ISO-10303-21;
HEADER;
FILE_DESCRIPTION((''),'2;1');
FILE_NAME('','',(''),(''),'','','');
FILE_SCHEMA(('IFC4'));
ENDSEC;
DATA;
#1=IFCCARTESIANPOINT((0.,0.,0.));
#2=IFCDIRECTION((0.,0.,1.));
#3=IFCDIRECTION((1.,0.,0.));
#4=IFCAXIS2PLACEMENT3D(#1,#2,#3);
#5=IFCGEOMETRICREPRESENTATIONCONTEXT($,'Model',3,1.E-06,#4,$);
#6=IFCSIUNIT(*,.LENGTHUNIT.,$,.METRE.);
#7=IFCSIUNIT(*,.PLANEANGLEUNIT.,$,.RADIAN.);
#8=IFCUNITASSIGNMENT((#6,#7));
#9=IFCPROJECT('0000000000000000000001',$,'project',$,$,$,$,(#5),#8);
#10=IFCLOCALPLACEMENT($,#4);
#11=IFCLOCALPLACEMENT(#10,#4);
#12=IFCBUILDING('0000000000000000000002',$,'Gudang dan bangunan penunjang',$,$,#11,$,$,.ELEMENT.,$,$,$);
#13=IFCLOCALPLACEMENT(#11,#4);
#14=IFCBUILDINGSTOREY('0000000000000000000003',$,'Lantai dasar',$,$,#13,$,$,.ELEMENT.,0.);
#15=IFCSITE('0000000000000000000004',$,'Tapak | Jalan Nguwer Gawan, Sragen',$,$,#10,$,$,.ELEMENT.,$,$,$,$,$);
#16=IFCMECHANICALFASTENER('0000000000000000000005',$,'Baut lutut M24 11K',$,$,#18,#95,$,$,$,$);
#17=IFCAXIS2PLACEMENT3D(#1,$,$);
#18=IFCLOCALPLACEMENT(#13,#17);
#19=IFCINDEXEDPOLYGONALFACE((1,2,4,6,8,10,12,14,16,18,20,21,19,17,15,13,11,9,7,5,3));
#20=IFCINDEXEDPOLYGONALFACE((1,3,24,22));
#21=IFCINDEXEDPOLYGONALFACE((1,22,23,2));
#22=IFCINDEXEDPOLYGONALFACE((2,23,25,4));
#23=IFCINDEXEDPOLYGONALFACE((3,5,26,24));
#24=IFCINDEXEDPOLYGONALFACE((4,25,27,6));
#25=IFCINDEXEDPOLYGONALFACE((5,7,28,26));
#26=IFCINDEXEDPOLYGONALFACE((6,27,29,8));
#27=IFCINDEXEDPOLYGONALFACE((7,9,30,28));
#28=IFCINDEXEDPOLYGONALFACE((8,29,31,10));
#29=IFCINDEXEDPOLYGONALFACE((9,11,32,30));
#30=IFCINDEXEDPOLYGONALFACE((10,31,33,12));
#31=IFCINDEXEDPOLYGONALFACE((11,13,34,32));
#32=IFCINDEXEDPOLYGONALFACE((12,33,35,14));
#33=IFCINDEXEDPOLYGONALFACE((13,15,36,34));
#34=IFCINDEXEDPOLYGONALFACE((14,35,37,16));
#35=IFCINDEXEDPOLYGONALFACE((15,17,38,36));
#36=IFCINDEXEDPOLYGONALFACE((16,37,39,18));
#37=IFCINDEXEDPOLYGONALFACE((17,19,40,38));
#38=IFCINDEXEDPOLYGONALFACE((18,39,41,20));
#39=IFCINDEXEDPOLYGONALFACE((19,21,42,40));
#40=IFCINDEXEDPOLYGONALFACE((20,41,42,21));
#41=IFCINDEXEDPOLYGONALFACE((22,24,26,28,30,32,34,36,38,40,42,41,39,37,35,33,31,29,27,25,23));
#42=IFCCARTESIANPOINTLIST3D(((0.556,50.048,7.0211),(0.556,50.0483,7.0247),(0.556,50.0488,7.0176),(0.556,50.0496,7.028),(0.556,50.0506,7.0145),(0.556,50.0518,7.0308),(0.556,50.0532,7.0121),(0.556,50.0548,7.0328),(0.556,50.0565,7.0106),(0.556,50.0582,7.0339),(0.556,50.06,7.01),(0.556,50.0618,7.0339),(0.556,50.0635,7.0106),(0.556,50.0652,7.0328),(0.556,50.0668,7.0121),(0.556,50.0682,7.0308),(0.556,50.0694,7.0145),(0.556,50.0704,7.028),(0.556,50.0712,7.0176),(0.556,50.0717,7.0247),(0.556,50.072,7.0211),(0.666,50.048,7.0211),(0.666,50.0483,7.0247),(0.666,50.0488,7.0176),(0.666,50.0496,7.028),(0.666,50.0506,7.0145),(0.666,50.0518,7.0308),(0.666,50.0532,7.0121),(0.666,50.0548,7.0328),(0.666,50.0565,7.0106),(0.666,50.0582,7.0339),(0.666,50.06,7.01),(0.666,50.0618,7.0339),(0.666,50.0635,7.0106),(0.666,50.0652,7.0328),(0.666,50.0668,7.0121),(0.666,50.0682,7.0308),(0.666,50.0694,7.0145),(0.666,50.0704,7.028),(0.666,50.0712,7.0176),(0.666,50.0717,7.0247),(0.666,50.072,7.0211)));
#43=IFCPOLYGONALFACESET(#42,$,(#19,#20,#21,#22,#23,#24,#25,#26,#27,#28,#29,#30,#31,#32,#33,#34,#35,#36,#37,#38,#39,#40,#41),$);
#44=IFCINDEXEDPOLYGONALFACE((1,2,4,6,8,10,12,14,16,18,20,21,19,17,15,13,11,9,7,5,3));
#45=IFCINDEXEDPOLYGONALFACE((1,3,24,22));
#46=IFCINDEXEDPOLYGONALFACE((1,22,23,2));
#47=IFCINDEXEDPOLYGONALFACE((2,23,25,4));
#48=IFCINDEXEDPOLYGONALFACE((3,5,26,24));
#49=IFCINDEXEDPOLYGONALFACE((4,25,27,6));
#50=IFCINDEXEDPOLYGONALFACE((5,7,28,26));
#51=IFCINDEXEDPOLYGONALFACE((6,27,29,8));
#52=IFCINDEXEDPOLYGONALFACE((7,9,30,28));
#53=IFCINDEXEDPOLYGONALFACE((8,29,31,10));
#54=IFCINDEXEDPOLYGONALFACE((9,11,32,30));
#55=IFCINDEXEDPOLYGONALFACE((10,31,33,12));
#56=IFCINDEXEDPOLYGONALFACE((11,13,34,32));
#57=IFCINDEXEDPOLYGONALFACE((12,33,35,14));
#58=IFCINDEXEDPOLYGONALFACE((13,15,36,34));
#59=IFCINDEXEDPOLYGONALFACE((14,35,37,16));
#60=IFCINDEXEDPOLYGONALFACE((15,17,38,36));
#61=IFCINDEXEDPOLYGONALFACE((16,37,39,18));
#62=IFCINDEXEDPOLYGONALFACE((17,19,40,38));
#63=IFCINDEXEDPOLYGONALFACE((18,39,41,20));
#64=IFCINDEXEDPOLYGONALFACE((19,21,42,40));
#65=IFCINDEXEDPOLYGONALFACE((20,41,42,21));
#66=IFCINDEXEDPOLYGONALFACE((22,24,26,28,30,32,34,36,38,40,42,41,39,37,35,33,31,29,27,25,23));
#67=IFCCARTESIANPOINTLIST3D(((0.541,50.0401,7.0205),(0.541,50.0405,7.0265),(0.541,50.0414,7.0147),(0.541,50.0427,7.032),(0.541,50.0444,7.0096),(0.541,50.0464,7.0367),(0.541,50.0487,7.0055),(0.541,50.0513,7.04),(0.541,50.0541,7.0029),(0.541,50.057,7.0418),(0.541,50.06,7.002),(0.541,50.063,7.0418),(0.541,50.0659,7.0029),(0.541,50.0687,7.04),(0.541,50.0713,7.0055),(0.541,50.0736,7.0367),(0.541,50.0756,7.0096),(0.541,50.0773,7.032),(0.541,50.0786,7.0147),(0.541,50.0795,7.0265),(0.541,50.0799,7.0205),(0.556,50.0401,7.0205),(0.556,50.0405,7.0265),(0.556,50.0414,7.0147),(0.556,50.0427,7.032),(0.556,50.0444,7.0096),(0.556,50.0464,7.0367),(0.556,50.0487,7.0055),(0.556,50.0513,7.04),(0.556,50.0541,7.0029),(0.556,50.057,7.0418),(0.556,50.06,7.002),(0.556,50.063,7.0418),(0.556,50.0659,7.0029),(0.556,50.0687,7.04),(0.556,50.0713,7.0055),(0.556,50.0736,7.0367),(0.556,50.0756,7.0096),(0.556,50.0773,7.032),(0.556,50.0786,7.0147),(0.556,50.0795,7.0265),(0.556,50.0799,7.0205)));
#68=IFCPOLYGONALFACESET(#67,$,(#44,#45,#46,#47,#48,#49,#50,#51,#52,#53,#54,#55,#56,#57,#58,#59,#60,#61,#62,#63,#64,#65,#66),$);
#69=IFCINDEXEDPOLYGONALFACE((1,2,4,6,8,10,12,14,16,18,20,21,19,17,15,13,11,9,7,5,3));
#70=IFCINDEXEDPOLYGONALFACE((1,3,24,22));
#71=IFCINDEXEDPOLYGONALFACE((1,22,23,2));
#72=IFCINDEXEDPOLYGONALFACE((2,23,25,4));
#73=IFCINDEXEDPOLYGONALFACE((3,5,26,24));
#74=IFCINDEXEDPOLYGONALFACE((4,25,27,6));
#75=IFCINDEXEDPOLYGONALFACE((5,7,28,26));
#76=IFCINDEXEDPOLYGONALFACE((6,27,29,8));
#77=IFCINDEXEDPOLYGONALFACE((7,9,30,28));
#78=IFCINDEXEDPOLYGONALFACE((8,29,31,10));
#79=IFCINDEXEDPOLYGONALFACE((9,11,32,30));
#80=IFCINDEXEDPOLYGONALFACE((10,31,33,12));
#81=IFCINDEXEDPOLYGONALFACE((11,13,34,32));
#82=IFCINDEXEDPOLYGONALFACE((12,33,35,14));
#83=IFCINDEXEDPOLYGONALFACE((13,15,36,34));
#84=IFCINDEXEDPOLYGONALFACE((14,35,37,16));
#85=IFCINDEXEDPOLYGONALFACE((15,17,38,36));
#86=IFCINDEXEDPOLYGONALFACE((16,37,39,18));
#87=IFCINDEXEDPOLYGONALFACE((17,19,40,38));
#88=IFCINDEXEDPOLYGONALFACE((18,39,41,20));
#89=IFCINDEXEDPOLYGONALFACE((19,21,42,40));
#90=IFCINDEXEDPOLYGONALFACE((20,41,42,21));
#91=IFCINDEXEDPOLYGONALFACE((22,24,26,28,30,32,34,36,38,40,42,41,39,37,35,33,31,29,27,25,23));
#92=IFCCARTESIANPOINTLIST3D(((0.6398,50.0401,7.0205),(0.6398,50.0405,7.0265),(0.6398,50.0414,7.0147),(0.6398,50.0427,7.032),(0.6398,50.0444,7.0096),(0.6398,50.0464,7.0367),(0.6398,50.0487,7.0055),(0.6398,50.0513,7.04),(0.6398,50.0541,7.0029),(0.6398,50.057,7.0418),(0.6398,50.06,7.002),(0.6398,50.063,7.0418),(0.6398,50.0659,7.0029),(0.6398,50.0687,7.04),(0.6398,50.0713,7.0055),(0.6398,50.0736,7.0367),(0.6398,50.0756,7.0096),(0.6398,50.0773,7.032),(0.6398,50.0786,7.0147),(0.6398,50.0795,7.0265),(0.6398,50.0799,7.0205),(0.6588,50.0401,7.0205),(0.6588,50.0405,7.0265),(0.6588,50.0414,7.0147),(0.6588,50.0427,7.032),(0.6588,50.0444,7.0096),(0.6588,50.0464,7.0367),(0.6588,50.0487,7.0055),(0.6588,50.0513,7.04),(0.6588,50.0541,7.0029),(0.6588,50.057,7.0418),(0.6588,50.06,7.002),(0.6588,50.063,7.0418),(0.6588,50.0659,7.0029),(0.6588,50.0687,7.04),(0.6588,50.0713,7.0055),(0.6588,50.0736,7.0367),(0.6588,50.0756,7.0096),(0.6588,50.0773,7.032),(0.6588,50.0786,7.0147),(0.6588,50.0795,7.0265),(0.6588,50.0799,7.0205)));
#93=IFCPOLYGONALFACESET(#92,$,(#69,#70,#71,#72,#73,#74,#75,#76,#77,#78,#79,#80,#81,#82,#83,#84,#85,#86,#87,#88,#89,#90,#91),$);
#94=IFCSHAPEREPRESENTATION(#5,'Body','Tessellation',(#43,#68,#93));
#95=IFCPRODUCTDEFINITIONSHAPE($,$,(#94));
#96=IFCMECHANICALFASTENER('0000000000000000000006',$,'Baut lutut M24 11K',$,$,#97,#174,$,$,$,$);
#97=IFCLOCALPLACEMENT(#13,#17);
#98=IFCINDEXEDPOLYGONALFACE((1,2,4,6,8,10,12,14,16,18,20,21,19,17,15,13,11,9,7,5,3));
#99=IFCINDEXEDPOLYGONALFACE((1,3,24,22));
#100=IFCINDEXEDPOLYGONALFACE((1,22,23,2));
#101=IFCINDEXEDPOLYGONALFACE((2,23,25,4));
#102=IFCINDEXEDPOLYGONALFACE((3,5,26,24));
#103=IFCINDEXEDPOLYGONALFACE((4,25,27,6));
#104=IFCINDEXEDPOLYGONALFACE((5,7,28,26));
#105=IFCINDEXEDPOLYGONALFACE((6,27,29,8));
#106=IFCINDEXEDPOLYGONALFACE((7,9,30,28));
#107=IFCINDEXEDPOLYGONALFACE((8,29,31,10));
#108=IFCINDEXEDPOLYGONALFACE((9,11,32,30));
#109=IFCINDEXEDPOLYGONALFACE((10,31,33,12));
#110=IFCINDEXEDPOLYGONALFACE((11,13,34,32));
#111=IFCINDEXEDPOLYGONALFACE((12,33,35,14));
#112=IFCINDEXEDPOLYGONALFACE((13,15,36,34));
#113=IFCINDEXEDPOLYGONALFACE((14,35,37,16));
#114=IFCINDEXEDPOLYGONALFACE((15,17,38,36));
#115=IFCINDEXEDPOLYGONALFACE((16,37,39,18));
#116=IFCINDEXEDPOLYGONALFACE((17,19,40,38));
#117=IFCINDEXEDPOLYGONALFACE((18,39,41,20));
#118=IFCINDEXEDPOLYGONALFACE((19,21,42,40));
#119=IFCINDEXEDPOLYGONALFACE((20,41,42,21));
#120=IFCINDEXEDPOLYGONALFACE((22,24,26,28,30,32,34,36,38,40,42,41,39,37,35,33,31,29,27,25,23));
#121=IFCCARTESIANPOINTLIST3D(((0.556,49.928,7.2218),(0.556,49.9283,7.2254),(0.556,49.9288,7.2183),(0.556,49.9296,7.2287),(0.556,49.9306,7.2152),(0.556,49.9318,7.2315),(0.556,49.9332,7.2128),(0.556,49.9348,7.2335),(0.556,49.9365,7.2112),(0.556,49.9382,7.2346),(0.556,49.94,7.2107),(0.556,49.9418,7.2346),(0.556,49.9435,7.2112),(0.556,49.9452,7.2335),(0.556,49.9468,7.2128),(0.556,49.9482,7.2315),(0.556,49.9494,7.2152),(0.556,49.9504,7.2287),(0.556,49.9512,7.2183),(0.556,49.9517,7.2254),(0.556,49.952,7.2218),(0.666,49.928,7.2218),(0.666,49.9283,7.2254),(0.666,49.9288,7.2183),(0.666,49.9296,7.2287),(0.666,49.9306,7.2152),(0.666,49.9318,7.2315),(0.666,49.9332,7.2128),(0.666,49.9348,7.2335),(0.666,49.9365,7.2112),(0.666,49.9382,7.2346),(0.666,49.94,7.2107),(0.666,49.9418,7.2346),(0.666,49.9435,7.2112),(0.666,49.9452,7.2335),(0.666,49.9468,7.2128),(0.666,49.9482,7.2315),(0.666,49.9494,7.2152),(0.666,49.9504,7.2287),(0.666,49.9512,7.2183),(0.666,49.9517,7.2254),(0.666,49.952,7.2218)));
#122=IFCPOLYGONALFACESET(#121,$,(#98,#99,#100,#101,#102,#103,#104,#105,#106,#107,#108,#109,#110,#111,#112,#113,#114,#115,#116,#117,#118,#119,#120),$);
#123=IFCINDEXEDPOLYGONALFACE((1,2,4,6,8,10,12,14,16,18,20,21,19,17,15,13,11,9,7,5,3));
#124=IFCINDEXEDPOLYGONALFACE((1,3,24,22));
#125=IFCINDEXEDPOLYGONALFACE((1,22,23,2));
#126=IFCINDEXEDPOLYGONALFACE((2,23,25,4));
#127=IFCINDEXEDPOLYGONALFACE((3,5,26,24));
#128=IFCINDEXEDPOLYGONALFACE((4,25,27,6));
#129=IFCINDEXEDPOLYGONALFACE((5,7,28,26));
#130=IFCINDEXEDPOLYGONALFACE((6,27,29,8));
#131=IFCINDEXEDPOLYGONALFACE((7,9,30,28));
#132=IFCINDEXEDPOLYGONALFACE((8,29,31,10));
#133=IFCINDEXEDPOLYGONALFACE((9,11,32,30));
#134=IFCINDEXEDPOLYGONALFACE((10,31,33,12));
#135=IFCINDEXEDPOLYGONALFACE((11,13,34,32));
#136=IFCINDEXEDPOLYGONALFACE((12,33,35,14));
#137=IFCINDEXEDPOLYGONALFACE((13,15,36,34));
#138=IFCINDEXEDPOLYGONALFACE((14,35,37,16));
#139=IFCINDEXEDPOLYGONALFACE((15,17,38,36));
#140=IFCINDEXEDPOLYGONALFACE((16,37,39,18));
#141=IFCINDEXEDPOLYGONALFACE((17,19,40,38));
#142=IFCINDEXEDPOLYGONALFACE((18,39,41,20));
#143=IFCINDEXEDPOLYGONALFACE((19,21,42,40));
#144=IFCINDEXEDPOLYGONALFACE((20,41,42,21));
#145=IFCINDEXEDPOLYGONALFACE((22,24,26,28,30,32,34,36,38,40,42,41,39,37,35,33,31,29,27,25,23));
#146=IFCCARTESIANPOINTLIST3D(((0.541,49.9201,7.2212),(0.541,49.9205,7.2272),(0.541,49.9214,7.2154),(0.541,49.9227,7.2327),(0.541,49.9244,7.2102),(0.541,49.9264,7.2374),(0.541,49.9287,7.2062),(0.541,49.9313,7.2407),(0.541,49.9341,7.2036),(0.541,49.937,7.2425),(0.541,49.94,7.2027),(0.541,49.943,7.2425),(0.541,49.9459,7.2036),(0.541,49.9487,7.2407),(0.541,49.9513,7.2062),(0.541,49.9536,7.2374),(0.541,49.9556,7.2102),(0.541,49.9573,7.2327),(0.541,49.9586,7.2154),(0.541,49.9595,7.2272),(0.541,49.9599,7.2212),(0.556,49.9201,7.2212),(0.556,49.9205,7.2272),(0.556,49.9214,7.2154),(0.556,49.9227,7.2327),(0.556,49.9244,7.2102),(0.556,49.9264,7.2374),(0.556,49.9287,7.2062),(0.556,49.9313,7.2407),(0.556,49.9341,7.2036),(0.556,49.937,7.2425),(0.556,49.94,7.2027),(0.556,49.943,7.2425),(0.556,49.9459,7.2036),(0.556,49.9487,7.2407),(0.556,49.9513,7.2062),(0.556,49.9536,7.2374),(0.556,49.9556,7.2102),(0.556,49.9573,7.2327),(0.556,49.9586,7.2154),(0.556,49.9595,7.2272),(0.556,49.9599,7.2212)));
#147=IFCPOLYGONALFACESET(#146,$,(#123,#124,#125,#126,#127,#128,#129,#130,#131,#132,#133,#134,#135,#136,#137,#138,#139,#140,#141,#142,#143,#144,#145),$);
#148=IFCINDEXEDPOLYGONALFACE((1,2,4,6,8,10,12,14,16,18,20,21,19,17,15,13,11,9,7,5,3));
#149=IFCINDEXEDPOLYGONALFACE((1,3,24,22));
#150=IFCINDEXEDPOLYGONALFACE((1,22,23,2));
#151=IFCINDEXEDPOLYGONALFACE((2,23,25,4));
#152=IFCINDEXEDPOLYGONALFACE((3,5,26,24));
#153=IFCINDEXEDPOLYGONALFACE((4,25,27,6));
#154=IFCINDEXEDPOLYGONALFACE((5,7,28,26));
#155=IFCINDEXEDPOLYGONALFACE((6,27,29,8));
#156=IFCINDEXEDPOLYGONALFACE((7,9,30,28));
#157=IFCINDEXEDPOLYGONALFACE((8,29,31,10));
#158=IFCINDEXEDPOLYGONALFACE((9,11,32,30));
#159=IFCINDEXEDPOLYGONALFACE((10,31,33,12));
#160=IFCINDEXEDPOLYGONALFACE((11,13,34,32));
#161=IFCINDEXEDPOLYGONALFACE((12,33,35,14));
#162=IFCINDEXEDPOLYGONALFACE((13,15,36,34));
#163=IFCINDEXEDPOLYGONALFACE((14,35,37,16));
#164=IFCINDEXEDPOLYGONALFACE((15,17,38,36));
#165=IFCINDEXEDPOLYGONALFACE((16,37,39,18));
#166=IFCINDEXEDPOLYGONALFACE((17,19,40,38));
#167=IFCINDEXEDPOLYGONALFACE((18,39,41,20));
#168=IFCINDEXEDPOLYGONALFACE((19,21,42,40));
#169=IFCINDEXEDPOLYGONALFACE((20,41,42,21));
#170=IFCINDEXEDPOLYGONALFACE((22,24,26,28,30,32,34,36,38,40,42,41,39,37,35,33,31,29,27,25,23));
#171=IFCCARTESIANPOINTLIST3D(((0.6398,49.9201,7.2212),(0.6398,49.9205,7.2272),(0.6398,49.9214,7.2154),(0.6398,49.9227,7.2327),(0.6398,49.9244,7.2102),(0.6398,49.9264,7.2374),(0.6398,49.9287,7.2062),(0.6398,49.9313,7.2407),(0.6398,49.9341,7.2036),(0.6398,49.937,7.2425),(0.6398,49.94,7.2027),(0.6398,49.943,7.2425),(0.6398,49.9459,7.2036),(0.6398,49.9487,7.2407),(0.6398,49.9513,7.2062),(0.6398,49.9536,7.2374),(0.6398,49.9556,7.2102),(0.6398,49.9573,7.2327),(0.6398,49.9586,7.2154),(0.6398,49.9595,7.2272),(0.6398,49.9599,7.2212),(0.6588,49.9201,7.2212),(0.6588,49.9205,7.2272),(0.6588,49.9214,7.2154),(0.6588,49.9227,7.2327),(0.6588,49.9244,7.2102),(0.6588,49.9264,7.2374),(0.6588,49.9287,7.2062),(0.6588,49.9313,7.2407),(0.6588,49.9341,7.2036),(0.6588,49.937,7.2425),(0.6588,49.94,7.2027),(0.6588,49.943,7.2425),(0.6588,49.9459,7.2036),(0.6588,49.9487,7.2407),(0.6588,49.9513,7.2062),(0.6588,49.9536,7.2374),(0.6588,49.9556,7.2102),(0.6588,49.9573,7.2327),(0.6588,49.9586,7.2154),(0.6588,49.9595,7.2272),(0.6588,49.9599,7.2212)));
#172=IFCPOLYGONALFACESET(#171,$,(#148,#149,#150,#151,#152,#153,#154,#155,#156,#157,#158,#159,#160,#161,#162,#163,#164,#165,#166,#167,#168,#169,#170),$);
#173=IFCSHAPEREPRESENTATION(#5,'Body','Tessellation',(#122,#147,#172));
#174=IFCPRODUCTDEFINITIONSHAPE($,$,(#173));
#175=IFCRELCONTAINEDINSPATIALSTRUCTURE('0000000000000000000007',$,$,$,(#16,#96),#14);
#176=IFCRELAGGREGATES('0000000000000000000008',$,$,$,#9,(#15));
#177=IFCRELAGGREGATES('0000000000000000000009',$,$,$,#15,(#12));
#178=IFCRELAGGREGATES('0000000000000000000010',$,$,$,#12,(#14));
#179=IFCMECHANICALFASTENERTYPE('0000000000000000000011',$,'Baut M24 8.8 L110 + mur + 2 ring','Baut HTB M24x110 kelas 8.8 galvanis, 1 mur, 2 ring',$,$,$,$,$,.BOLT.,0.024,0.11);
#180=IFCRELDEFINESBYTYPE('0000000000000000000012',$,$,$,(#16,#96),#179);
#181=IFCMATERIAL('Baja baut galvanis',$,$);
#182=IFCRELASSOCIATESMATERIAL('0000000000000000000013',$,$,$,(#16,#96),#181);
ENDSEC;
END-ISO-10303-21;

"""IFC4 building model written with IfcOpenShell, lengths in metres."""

from ifc_helpers import new_model, si_unit, frame, origin_with_axes, place, context, project, spatial, circle, extrude, source, transform, mapped, material, type_object, type_shapes, element, save


model = new_model("IFC4")

# Units and contexts
model_context = context("Model", 3, precision=1e-06, world=origin_with_axes())
ifc_project = project(units=[si_unit("LENGTHUNIT", "METRE"), si_unit("PLANEANGLEUNIT", "RADIAN")], contexts=[model_context])

# Site, building, storey
site_placement = place(None, origin_with_axes())
site = spatial("IfcSite", under=ifc_project, at=site_placement, Name="Tapak | Jalan Nguwer Gawan, Sragen", CompositionType="ELEMENT")
building_placement = place(site_placement, origin_with_axes())
building = spatial("IfcBuilding", under=site, at=building_placement, Name="Gudang dan bangunan penunjang", CompositionType="ELEMENT")
storey_placement = place(building_placement, origin_with_axes())
storey = spatial("IfcBuildingStorey", under=building, at=storey_placement, Name="Lantai dasar", CompositionType="ELEMENT", Elevation=0.0)

# Shared definitions
placement = place(None, origin_with_axes())

# Mechanical fasteners
ifc_material_1 = material(Name="Baja baut galvanis")
mechanical_fastener_type_1 = type_object("IfcMechanicalFastenerType", Name="Baut M24 8.8 L110 + mur + 2 ring", Description="Baut HTB M24x110 kelas 8.8 galvanis, 1 mur, 2 ring", NominalDiameter=0.024, NominalLength=0.11, PredefinedType="BOLT")
shared_shape_1 = source(origin_with_axes(), model_context, "Body", "SweptSolid", [
    extrude(circle(Radius=0.012), origin_with_axes(), (0.0, 0.0, 1.0), 0.11),
    extrude(circle(Radius=0.02), frame((0.0, 0.0, -0.015), z_axis=(0.0, 0.0, 1.0), x_axis=(1.0, 0.0, 0.0)), (0.0, 0.0, 1.0), 0.015),
    extrude(circle(Radius=0.02), frame((0.0, 0.0, 0.0838), z_axis=(0.0, 0.0, 1.0), x_axis=(1.0, 0.0, 0.0)), (0.0, 0.0, 1.0), 0.019),
])
type_shapes(mechanical_fastener_type_1, [shared_shape_1])
element("IfcMechanicalFastener", 1, at=placement, inside=storey, type_object=mechanical_fastener_type_1, material=ifc_material_1, Name="Baut lutut M24 11K", context=model_context, shape_type="MappedRepresentation", body=[
    mapped(shared_shape_1, transform((0.556, 50.06, 7.022), x_axis=(0.0, 0.0, -1.0), y_axis=(0.0, 1.0, 0.0), z_axis=(1.0, 0.0, 0.0), scale=1.0)),
])
element("IfcMechanicalFastener", 2, at=placement, inside=storey, type_object=mechanical_fastener_type_1, material=ifc_material_1, Name="Baut lutut M24 11K", context=model_context, shape_type="MappedRepresentation", body=[
    mapped(shared_shape_1, transform((0.556, 49.94, 7.2227), x_axis=(0.0, 0.0, -1.0), y_axis=(0.0, 1.0, 0.0), z_axis=(1.0, 0.0, 0.0), scale=1.0)),
])

save(model, "model.ifc")
